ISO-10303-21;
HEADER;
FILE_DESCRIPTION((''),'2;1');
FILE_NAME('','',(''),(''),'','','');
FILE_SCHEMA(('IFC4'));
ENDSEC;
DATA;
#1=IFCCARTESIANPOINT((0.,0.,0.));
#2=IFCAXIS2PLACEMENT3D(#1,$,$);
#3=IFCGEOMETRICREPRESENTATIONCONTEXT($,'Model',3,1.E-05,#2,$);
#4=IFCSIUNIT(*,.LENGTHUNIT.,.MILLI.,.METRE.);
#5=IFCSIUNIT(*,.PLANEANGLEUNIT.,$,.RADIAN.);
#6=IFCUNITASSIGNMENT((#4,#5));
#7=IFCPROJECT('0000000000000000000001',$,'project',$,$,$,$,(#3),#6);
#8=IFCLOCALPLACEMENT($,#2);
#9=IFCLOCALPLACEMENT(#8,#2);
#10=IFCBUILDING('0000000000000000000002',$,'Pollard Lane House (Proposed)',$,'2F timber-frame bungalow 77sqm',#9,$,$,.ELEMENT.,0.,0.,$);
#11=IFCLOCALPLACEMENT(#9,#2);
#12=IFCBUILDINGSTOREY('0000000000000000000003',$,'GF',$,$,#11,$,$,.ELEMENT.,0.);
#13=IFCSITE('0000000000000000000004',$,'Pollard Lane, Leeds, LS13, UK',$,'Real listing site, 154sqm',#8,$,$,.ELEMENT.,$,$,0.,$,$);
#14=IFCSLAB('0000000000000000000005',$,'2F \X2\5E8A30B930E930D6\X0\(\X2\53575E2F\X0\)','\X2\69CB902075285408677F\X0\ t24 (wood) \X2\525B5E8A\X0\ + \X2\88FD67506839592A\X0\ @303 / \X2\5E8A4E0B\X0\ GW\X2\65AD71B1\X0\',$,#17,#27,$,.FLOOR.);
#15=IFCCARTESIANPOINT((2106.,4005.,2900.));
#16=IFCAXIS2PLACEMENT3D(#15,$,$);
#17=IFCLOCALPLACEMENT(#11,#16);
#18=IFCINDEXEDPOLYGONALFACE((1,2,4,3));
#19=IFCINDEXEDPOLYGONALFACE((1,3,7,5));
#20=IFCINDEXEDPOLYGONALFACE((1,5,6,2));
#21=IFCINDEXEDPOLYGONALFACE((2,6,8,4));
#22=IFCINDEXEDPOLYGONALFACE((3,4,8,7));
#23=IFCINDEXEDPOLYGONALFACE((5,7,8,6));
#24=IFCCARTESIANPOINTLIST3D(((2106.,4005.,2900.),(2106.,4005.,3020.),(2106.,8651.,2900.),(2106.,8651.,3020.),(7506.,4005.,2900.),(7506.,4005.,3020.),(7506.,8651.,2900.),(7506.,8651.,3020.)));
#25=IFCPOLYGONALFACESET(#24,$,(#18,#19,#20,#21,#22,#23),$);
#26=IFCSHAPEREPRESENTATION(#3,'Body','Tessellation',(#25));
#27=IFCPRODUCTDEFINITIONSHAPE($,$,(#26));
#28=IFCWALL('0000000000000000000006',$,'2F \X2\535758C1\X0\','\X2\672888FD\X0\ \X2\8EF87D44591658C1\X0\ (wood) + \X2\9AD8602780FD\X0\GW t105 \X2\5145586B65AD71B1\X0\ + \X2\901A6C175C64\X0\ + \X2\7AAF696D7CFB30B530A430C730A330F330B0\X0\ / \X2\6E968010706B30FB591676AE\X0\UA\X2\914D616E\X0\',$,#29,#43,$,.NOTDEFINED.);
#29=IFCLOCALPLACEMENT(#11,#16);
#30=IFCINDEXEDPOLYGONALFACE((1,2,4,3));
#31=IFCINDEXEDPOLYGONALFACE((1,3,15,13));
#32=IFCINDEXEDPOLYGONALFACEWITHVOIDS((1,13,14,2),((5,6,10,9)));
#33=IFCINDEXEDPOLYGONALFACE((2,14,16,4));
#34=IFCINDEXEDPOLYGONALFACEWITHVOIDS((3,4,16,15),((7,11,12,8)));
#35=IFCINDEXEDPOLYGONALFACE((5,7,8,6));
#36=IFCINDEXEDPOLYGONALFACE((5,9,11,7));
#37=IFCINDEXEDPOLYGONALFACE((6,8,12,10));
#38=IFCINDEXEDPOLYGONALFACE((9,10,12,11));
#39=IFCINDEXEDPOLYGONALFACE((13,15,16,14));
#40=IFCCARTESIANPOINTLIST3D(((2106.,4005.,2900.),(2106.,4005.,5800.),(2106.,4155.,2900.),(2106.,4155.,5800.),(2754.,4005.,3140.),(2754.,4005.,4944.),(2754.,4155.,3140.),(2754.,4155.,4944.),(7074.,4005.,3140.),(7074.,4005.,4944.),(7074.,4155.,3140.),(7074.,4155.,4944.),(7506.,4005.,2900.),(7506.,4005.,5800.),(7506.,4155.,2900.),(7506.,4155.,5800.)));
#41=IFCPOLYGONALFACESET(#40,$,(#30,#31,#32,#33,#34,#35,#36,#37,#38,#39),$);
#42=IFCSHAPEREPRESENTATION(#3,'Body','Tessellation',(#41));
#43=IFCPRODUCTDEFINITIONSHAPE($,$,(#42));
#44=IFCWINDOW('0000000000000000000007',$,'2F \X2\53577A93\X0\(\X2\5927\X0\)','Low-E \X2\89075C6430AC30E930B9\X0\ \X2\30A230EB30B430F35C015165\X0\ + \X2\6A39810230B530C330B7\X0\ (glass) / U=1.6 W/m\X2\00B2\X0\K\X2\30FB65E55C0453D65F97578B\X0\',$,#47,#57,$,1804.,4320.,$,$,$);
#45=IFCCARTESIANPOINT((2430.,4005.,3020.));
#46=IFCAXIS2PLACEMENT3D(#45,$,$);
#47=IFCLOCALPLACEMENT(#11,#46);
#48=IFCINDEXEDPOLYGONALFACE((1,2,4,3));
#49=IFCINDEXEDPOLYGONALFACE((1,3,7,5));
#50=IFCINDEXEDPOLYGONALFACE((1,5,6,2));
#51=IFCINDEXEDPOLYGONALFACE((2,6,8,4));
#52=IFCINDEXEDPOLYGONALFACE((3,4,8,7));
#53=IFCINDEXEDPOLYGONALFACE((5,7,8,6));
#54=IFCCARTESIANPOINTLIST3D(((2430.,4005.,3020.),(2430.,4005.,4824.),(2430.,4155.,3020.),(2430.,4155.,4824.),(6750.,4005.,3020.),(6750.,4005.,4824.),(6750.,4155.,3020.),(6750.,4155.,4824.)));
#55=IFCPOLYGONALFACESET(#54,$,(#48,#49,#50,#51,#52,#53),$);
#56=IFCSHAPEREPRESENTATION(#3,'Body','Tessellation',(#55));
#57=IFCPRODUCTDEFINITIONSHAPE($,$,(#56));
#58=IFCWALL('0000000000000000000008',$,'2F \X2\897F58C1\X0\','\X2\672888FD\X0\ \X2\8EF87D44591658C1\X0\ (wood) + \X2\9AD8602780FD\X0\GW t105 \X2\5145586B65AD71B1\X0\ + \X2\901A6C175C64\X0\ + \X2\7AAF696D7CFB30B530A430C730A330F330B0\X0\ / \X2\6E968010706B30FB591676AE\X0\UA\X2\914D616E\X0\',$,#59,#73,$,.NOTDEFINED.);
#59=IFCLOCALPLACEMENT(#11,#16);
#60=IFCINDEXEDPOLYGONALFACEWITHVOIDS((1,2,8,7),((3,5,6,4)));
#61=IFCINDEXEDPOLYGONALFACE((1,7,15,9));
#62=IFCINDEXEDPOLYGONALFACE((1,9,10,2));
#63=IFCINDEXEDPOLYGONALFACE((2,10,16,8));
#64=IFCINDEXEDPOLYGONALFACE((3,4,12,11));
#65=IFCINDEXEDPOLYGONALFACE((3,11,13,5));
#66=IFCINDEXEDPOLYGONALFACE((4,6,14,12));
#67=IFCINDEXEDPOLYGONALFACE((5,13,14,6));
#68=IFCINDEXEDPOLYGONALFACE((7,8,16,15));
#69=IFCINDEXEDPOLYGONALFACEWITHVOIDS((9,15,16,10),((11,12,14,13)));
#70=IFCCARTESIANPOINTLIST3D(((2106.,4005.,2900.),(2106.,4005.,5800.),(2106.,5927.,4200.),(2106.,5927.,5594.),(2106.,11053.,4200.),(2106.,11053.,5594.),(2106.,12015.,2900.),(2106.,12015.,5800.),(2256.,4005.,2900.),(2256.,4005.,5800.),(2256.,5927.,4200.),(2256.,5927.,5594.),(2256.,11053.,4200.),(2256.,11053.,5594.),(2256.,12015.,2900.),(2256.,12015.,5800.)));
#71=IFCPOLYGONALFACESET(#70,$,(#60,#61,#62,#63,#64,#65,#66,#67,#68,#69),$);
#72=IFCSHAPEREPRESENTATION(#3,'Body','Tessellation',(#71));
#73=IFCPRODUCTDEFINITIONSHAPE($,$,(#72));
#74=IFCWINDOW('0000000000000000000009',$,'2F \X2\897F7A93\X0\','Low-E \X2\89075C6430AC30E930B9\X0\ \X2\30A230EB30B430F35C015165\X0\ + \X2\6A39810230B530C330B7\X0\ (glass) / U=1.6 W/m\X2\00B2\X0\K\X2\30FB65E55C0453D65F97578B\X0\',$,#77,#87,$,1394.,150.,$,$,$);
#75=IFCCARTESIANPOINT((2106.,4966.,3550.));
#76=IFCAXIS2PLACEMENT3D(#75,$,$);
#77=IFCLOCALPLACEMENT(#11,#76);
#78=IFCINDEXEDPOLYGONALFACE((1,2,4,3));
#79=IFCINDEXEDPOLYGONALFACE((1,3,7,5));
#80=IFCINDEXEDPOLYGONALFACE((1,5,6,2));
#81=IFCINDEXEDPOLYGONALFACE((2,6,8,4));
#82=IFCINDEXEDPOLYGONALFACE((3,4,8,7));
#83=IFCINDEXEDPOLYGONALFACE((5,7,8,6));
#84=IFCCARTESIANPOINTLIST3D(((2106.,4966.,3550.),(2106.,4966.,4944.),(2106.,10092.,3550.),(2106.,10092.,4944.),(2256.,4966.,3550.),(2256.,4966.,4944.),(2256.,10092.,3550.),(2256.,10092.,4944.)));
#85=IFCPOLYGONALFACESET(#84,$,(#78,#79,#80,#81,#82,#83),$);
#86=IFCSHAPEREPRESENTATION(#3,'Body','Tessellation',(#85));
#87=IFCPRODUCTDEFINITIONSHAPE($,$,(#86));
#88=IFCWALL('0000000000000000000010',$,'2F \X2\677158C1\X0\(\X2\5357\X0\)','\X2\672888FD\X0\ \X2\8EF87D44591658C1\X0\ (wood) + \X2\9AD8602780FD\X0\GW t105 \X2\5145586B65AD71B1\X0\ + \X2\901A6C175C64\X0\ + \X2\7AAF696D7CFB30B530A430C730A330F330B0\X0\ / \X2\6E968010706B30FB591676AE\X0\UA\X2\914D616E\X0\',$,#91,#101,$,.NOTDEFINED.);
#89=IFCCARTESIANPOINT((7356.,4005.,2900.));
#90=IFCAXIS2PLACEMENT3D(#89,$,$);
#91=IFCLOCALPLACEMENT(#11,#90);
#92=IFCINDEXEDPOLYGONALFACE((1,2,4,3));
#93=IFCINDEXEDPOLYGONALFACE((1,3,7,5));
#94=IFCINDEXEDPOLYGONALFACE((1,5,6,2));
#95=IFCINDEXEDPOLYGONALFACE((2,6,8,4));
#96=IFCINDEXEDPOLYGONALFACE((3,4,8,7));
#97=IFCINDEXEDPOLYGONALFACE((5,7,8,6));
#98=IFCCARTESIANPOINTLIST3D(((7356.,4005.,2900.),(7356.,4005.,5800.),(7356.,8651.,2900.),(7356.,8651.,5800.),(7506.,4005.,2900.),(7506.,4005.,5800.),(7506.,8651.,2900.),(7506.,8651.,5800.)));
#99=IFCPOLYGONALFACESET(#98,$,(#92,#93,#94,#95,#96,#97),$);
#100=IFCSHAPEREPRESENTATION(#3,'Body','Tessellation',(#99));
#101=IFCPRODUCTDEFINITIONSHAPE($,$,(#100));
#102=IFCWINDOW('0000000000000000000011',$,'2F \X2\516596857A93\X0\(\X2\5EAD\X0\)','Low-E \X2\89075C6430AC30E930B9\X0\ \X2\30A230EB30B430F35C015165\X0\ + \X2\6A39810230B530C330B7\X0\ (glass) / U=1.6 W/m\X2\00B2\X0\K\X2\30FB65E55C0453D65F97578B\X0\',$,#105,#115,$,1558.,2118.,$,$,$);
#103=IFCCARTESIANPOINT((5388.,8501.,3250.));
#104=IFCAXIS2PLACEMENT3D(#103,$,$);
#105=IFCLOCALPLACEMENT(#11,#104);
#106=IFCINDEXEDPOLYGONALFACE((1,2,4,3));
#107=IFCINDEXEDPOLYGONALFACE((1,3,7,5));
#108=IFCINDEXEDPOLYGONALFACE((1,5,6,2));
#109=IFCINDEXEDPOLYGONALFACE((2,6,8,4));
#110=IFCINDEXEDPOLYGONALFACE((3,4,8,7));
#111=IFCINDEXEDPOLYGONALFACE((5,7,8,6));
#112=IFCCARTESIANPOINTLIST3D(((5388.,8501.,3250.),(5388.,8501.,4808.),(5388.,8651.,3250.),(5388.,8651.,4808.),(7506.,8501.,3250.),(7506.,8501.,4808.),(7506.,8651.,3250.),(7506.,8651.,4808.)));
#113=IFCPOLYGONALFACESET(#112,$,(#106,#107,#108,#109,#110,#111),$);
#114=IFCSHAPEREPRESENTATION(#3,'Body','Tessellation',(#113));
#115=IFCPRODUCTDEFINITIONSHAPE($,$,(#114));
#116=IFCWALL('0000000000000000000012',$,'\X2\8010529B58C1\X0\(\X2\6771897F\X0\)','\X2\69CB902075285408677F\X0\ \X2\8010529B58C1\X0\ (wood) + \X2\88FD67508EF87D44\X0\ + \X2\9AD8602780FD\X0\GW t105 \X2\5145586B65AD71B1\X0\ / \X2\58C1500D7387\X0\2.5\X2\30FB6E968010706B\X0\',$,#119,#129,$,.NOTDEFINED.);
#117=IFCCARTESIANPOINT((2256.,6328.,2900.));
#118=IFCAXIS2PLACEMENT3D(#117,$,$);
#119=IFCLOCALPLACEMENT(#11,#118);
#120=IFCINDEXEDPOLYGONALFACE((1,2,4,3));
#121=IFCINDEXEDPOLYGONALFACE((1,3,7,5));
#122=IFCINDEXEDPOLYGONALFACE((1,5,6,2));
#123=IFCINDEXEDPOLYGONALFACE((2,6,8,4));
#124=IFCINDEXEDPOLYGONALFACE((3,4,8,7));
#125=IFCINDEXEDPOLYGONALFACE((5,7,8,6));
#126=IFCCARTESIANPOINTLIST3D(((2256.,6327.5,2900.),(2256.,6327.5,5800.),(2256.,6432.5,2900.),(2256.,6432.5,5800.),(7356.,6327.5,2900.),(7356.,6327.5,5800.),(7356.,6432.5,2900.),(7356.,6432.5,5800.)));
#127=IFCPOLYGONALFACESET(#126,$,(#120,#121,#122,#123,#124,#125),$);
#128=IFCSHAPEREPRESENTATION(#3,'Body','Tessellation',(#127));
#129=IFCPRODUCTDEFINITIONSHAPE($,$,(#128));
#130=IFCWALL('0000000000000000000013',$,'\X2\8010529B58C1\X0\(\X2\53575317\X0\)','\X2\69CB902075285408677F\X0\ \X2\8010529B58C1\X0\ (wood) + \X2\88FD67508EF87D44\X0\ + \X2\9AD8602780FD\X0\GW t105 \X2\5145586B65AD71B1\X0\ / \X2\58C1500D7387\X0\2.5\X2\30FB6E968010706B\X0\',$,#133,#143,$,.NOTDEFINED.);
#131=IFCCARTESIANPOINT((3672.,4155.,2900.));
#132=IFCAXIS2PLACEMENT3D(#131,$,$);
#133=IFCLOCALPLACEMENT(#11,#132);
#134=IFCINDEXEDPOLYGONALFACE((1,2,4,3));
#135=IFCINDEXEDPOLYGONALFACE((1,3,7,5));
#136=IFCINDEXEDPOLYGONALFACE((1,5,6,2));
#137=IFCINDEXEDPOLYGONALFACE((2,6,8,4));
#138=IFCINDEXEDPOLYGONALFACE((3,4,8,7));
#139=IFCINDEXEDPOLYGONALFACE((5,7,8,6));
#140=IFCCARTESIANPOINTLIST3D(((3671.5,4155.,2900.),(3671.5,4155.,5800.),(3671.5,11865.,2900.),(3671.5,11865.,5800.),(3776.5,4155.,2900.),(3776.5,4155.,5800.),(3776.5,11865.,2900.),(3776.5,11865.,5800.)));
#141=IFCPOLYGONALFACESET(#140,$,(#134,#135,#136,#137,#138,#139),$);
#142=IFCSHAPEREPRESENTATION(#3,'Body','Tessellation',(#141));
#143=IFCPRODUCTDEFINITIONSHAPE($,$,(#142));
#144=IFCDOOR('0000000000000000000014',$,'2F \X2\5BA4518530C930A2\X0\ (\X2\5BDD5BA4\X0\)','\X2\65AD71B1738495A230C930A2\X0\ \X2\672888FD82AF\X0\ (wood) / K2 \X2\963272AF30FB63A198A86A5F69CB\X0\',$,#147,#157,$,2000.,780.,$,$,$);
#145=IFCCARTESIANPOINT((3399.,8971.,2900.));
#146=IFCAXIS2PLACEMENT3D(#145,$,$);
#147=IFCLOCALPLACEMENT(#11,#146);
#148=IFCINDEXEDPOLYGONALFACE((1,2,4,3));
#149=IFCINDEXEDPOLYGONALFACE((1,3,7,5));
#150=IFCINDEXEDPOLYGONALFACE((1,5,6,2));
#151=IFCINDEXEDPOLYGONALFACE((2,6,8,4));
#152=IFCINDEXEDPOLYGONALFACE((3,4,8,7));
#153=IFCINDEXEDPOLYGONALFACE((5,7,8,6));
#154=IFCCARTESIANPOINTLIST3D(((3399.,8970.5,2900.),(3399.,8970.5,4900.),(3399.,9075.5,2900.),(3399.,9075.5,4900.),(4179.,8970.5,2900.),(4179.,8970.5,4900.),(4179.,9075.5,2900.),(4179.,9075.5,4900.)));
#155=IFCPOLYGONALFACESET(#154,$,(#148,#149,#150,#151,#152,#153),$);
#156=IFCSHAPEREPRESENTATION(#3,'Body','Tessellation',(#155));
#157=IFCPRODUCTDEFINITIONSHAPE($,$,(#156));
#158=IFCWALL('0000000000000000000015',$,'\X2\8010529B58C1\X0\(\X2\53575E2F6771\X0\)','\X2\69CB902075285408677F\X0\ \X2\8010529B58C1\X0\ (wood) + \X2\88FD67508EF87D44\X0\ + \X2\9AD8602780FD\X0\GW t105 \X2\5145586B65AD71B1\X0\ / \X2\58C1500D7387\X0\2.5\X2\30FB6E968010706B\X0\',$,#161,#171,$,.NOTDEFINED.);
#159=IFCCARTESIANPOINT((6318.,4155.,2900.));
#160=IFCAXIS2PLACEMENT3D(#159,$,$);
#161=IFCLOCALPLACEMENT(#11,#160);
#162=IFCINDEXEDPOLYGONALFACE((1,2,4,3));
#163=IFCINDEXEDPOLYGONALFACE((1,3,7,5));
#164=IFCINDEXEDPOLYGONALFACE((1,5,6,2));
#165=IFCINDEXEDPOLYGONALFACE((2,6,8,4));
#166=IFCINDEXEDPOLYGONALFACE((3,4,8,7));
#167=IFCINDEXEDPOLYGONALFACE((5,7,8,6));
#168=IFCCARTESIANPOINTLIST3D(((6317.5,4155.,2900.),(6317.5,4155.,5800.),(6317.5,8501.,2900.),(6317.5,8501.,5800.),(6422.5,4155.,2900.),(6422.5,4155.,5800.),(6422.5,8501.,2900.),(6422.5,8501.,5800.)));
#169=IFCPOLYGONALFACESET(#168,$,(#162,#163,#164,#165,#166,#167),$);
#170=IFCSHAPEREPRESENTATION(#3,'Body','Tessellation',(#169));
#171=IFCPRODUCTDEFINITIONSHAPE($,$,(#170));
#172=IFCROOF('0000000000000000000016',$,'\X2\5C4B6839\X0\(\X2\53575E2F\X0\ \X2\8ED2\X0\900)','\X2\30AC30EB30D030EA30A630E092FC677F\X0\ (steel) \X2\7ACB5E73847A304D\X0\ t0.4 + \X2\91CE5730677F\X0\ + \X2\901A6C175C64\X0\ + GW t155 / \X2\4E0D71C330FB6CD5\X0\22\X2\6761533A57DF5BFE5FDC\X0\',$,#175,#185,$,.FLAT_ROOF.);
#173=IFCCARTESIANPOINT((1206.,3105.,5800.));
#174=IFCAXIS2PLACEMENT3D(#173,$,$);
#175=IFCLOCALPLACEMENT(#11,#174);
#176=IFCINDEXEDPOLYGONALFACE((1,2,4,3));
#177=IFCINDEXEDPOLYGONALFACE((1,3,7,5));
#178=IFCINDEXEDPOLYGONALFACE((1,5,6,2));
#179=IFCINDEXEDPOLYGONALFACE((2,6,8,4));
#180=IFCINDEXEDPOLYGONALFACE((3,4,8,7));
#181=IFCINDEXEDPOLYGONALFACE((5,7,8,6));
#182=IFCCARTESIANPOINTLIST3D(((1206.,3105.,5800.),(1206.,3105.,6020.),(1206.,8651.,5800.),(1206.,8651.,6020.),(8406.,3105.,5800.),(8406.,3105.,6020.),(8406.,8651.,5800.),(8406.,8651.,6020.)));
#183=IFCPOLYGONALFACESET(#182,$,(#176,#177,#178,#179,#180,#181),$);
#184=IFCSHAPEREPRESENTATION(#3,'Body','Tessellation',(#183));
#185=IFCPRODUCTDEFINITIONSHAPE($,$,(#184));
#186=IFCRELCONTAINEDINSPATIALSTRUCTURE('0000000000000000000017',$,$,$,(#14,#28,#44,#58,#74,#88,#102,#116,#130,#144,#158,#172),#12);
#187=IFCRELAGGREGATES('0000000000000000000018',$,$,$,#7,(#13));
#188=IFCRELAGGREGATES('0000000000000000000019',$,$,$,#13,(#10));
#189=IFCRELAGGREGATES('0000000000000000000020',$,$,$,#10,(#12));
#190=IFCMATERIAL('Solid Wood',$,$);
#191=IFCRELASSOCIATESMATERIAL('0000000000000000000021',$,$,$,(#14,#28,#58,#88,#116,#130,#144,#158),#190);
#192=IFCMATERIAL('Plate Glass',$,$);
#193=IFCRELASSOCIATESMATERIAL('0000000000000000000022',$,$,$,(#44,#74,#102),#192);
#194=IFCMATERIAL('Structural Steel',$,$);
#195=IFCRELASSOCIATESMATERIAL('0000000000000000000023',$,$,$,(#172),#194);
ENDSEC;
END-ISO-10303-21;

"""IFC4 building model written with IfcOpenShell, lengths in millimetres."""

from ifc_helpers import new_model, si_unit, frame, frame_2d, origin, place, context, project, spatial, rectangle, extrude, material, element, fill, save


model = new_model("IFC4")

# Units and contexts
model_context = context("Model", 3, precision=1e-05, world=origin())
ifc_project = project(units=[si_unit("LENGTHUNIT", "METRE", prefix="MILLI"), si_unit("PLANEANGLEUNIT", "RADIAN")], contexts=[model_context])

# Site, building, storey
site_placement = place(None, origin())
site = spatial("IfcSite", under=ifc_project, at=site_placement, Name="Pollard Lane, Leeds, LS13, UK", ObjectType="Real listing site, 154sqm", CompositionType="ELEMENT", RefElevation=0.0)
building_placement = place(site_placement, origin())
building = spatial("IfcBuilding", under=site, at=building_placement, Name="Pollard Lane House (Proposed)", ObjectType="2F timber-frame bungalow 77sqm", CompositionType="ELEMENT", ElevationOfRefHeight=0.0, ElevationOfTerrain=0.0)
storey_placement = place(building_placement, origin())
storey = spatial("IfcBuildingStorey", under=building, at=storey_placement, Name="GF", CompositionType="ELEMENT", Elevation=0.0)

# Slab
ifc_material_1 = material(Name="Solid Wood")
slab_placement = place(storey_placement, frame((2106.0, 4005.0, 2900.0)))
element("IfcSlab", 1, at=slab_placement, inside=storey, material=ifc_material_1, Name="2F 床スラブ(南帯)", Description="構造用合板 t24 (wood) 剛床 + 製材根太 @303 / 床下 GW断熱", PredefinedType="FLOOR", context=model_context, shape_type="SweptSolid", body=[
    extrude(rectangle(XDim=5400.0, YDim=4646.0, at=frame_2d((2700.0, 2323.0))), frame((2106.0, 4005.0, 2900.0)), (0.0, 0.0, 1.0), 120.0),
])

# Walls, openings, windows
wall_1_placement = place(storey_placement, frame((2106.0, 4005.0, 2900.0)))
wall_1 = element("IfcWall", 2, at=wall_1_placement, inside=storey, material=ifc_material_1, Name="2F 南壁", Description="木製 軸組外壁 (wood) + 高性能GW t105 充填断熱 + 通気層 + 窯業系サイディング / 準耐火・外皮UA配慮", PredefinedType="NOTDEFINED", context=model_context, shape_type="SweptSolid", body=[
    extrude(rectangle(XDim=5400.0, YDim=150.0, at=frame_2d((2700.0, 75.0))), frame((2106.0, 4005.0, 2900.0)), (0.0, 0.0, 1.0), 2900.0),
])
opening_1_placement = place(storey_placement, frame((2430.0, 4005.0, 3020.0)))
opening_1 = element("IfcOpeningElement", 3, at=opening_1_placement, cuts=wall_1, PredefinedType="NOTDEFINED", context=model_context, shape_type="SweptSolid", body=[
    extrude(rectangle(XDim=4320.0, YDim=150.0, at=frame_2d((2160.0, 75.0))), frame((2430.0, 4005.0, 3020.0)), (0.0, 0.0, 1.0), 1804.0),
])
ifc_material_2 = material(Name="Plate Glass")
window_1_placement = place(storey_placement, frame((2430.0, 4005.0, 3020.0)))
window_1 = element("IfcWindow", 4, at=window_1_placement, inside=storey, material=ifc_material_2, Name="2F 南窓(大)", Description="Low-E 複層ガラス アルゴン封入 + 樹脂サッシ (glass) / U=1.6 W/m²K・日射取得型", OverallHeight=1804.0, OverallWidth=4320.0, context=model_context, shape_type="SweptSolid", body=[
    extrude(rectangle(XDim=4320.0, YDim=150.0, at=frame_2d((2160.0, 75.0))), frame((2430.0, 4005.0, 3020.0)), (0.0, 0.0, 1.0), 1804.0),
])
fill(opening_1, window_1)
wall_2_placement = place(storey_placement, frame((2106.0, 4005.0, 2900.0)))
wall_2 = element("IfcWall", 5, at=wall_2_placement, inside=storey, material=ifc_material_1, Name="2F 西壁", Description="木製 軸組外壁 (wood) + 高性能GW t105 充填断熱 + 通気層 + 窯業系サイディング / 準耐火・外皮UA配慮", PredefinedType="NOTDEFINED", context=model_context, shape_type="SweptSolid", body=[
    extrude(rectangle(XDim=150.0, YDim=8010.0, at=frame_2d((75.0, 4005.0))), frame((2106.0, 4005.0, 2900.0)), (0.0, 0.0, 1.0), 2900.0),
])
opening_2_placement = place(storey_placement, frame((2106.0, 4966.0, 3550.0)))
opening_2 = element("IfcOpeningElement", 6, at=opening_2_placement, cuts=wall_2, PredefinedType="NOTDEFINED", context=model_context, shape_type="SweptSolid", body=[
    extrude(rectangle(XDim=150.0, YDim=5126.0, at=frame_2d((75.0, 2563.0))), frame((2106.0, 4966.0, 3550.0)), (0.0, 0.0, 1.0), 1394.0),
])
window_2_placement = place(storey_placement, frame((2106.0, 4966.0, 3550.0)))
window_2 = element("IfcWindow", 7, at=window_2_placement, inside=storey, material=ifc_material_2, Name="2F 西窓", Description="Low-E 複層ガラス アルゴン封入 + 樹脂サッシ (glass) / U=1.6 W/m²K・日射取得型", OverallHeight=1394.0, OverallWidth=150.0, context=model_context, shape_type="SweptSolid", body=[
    extrude(rectangle(XDim=150.0, YDim=5126.0, at=frame_2d((75.0, 2563.0))), frame((2106.0, 4966.0, 3550.0)), (0.0, 0.0, 1.0), 1394.0),
])
fill(opening_2, window_2)
wall_3_placement = place(storey_placement, frame((7356.0, 4005.0, 2900.0)))
wall_3 = element("IfcWall", 8, at=wall_3_placement, inside=storey, material=ifc_material_1, Name="2F 東壁(南)", Description="木製 軸組外壁 (wood) + 高性能GW t105 充填断熱 + 通気層 + 窯業系サイディング / 準耐火・外皮UA配慮", PredefinedType="NOTDEFINED", context=model_context, shape_type="SweptSolid", body=[
    extrude(rectangle(XDim=150.0, YDim=4646.0, at=frame_2d((75.0, 2323.0))), frame((7356.0, 4005.0, 2900.0)), (0.0, 0.0, 1.0), 2900.0),
])
opening_3_placement = place(storey_placement, frame((5388.0, 8501.0, 3250.0)))
opening_3 = element("IfcOpeningElement", 9, at=opening_3_placement, cuts=wall_3, PredefinedType="NOTDEFINED", context=model_context, shape_type="SweptSolid", body=[
    extrude(rectangle(XDim=2118.0, YDim=150.0, at=frame_2d((1059.0, 75.0))), frame((5388.0, 8501.0, 3250.0)), (0.0, 0.0, 1.0), 1558.0),
])
window_3_placement = place(storey_placement, frame((5388.0, 8501.0, 3250.0)))
window_3 = element("IfcWindow", 10, at=window_3_placement, inside=storey, material=ifc_material_2, Name="2F 入隅窓(庭)", Description="Low-E 複層ガラス アルゴン封入 + 樹脂サッシ (glass) / U=1.6 W/m²K・日射取得型", OverallHeight=1558.0, OverallWidth=2118.0, context=model_context, shape_type="SweptSolid", body=[
    extrude(rectangle(XDim=2118.0, YDim=150.0, at=frame_2d((1059.0, 75.0))), frame((5388.0, 8501.0, 3250.0)), (0.0, 0.0, 1.0), 1558.0),
])
fill(opening_3, window_3)

# Wall
wall_4_placement = place(storey_placement, frame((2256.0, 6328.0, 2900.0)))
element("IfcWall", 11, at=wall_4_placement, inside=storey, material=ifc_material_1, Name="耐力壁(東西)", Description="構造用合板 耐力壁 (wood) + 製材軸組 + 高性能GW t105 充填断熱 / 壁倍率2.5・準耐火", PredefinedType="NOTDEFINED", context=model_context, shape_type="SweptSolid", body=[
    extrude(rectangle(XDim=5100.0, YDim=105.0, at=frame_2d((2550.0, 52.0))), frame((2256.0, 6328.0, 2900.0)), (0.0, 0.0, 1.0), 2900.0),
])

# Wall, opening, door
wall_5_placement = place(storey_placement, frame((3672.0, 4155.0, 2900.0)))
wall_5 = element("IfcWall", 12, at=wall_5_placement, inside=storey, material=ifc_material_1, Name="耐力壁(南北)", Description="構造用合板 耐力壁 (wood) + 製材軸組 + 高性能GW t105 充填断熱 / 壁倍率2.5・準耐火", PredefinedType="NOTDEFINED", context=model_context, shape_type="SweptSolid", body=[
    extrude(rectangle(XDim=105.0, YDim=7710.0, at=frame_2d((52.0, 3855.0))), frame((3672.0, 4155.0, 2900.0)), (0.0, 0.0, 1.0), 2900.0),
])
opening_4_placement = place(storey_placement, frame((3399.0, 8971.0, 2900.0)))
opening_4 = element("IfcOpeningElement", 13, at=opening_4_placement, cuts=wall_5, PredefinedType="NOTDEFINED", context=model_context, shape_type="SweptSolid", body=[
    extrude(rectangle(XDim=780.0, YDim=105.0, at=frame_2d((390.0, 52.0))), frame((3399.0, 8971.0, 2900.0)), (0.0, 0.0, 1.0), 2000.0),
])
door_placement = place(storey_placement, frame((3399.0, 8971.0, 2900.0)))
door = element("IfcDoor", 14, at=door_placement, inside=storey, material=ifc_material_1, Name="2F 室内ドア (寝室)", Description="断熱玄関ドア 木製芯 (wood) / K2 防犯・採風機構", OverallHeight=2000.0, OverallWidth=780.0, context=model_context, shape_type="SweptSolid", body=[
    extrude(rectangle(XDim=780.0, YDim=105.0, at=frame_2d((390.0, 52.0))), frame((3399.0, 8971.0, 2900.0)), (0.0, 0.0, 1.0), 2000.0),
])
fill(opening_4, door)

# Wall
wall_6_placement = place(storey_placement, frame((6318.0, 4155.0, 2900.0)))
element("IfcWall", 15, at=wall_6_placement, inside=storey, material=ifc_material_1, Name="耐力壁(南帯東)", Description="構造用合板 耐力壁 (wood) + 製材軸組 + 高性能GW t105 充填断熱 / 壁倍率2.5・準耐火", PredefinedType="NOTDEFINED", context=model_context, shape_type="SweptSolid", body=[
    extrude(rectangle(XDim=105.0, YDim=4346.0, at=frame_2d((52.0, 2173.0))), frame((6318.0, 4155.0, 2900.0)), (0.0, 0.0, 1.0), 2900.0),
])

# Roof
ifc_material_3 = material(Name="Structural Steel")
for number, where, name in (
    (16, (1206.0, 3105.0, 5800.0), "屋根(南帯 軒900)"),
):
    element("IfcRoof", number, at=place(storey_placement, frame(where)), inside=storey, material=ifc_material_3, Name=name, Description="ガルバリウム鋼板 (steel) 立平葺き t0.4 + 野地板 + 通気層 + GW t155 / 不燃・法22条区域対応", PredefinedType="FLAT_ROOF", context=model_context, shape_type="SweptSolid", body=[
        extrude(rectangle(XDim=7200.0, YDim=5546.0, at=frame_2d((3600.0, 2773.0))), frame((1206.0, 3105.0, 5800.0)), (0.0, 0.0, 1.0), 220.0),
    ])

save(model, "model.ifc")
